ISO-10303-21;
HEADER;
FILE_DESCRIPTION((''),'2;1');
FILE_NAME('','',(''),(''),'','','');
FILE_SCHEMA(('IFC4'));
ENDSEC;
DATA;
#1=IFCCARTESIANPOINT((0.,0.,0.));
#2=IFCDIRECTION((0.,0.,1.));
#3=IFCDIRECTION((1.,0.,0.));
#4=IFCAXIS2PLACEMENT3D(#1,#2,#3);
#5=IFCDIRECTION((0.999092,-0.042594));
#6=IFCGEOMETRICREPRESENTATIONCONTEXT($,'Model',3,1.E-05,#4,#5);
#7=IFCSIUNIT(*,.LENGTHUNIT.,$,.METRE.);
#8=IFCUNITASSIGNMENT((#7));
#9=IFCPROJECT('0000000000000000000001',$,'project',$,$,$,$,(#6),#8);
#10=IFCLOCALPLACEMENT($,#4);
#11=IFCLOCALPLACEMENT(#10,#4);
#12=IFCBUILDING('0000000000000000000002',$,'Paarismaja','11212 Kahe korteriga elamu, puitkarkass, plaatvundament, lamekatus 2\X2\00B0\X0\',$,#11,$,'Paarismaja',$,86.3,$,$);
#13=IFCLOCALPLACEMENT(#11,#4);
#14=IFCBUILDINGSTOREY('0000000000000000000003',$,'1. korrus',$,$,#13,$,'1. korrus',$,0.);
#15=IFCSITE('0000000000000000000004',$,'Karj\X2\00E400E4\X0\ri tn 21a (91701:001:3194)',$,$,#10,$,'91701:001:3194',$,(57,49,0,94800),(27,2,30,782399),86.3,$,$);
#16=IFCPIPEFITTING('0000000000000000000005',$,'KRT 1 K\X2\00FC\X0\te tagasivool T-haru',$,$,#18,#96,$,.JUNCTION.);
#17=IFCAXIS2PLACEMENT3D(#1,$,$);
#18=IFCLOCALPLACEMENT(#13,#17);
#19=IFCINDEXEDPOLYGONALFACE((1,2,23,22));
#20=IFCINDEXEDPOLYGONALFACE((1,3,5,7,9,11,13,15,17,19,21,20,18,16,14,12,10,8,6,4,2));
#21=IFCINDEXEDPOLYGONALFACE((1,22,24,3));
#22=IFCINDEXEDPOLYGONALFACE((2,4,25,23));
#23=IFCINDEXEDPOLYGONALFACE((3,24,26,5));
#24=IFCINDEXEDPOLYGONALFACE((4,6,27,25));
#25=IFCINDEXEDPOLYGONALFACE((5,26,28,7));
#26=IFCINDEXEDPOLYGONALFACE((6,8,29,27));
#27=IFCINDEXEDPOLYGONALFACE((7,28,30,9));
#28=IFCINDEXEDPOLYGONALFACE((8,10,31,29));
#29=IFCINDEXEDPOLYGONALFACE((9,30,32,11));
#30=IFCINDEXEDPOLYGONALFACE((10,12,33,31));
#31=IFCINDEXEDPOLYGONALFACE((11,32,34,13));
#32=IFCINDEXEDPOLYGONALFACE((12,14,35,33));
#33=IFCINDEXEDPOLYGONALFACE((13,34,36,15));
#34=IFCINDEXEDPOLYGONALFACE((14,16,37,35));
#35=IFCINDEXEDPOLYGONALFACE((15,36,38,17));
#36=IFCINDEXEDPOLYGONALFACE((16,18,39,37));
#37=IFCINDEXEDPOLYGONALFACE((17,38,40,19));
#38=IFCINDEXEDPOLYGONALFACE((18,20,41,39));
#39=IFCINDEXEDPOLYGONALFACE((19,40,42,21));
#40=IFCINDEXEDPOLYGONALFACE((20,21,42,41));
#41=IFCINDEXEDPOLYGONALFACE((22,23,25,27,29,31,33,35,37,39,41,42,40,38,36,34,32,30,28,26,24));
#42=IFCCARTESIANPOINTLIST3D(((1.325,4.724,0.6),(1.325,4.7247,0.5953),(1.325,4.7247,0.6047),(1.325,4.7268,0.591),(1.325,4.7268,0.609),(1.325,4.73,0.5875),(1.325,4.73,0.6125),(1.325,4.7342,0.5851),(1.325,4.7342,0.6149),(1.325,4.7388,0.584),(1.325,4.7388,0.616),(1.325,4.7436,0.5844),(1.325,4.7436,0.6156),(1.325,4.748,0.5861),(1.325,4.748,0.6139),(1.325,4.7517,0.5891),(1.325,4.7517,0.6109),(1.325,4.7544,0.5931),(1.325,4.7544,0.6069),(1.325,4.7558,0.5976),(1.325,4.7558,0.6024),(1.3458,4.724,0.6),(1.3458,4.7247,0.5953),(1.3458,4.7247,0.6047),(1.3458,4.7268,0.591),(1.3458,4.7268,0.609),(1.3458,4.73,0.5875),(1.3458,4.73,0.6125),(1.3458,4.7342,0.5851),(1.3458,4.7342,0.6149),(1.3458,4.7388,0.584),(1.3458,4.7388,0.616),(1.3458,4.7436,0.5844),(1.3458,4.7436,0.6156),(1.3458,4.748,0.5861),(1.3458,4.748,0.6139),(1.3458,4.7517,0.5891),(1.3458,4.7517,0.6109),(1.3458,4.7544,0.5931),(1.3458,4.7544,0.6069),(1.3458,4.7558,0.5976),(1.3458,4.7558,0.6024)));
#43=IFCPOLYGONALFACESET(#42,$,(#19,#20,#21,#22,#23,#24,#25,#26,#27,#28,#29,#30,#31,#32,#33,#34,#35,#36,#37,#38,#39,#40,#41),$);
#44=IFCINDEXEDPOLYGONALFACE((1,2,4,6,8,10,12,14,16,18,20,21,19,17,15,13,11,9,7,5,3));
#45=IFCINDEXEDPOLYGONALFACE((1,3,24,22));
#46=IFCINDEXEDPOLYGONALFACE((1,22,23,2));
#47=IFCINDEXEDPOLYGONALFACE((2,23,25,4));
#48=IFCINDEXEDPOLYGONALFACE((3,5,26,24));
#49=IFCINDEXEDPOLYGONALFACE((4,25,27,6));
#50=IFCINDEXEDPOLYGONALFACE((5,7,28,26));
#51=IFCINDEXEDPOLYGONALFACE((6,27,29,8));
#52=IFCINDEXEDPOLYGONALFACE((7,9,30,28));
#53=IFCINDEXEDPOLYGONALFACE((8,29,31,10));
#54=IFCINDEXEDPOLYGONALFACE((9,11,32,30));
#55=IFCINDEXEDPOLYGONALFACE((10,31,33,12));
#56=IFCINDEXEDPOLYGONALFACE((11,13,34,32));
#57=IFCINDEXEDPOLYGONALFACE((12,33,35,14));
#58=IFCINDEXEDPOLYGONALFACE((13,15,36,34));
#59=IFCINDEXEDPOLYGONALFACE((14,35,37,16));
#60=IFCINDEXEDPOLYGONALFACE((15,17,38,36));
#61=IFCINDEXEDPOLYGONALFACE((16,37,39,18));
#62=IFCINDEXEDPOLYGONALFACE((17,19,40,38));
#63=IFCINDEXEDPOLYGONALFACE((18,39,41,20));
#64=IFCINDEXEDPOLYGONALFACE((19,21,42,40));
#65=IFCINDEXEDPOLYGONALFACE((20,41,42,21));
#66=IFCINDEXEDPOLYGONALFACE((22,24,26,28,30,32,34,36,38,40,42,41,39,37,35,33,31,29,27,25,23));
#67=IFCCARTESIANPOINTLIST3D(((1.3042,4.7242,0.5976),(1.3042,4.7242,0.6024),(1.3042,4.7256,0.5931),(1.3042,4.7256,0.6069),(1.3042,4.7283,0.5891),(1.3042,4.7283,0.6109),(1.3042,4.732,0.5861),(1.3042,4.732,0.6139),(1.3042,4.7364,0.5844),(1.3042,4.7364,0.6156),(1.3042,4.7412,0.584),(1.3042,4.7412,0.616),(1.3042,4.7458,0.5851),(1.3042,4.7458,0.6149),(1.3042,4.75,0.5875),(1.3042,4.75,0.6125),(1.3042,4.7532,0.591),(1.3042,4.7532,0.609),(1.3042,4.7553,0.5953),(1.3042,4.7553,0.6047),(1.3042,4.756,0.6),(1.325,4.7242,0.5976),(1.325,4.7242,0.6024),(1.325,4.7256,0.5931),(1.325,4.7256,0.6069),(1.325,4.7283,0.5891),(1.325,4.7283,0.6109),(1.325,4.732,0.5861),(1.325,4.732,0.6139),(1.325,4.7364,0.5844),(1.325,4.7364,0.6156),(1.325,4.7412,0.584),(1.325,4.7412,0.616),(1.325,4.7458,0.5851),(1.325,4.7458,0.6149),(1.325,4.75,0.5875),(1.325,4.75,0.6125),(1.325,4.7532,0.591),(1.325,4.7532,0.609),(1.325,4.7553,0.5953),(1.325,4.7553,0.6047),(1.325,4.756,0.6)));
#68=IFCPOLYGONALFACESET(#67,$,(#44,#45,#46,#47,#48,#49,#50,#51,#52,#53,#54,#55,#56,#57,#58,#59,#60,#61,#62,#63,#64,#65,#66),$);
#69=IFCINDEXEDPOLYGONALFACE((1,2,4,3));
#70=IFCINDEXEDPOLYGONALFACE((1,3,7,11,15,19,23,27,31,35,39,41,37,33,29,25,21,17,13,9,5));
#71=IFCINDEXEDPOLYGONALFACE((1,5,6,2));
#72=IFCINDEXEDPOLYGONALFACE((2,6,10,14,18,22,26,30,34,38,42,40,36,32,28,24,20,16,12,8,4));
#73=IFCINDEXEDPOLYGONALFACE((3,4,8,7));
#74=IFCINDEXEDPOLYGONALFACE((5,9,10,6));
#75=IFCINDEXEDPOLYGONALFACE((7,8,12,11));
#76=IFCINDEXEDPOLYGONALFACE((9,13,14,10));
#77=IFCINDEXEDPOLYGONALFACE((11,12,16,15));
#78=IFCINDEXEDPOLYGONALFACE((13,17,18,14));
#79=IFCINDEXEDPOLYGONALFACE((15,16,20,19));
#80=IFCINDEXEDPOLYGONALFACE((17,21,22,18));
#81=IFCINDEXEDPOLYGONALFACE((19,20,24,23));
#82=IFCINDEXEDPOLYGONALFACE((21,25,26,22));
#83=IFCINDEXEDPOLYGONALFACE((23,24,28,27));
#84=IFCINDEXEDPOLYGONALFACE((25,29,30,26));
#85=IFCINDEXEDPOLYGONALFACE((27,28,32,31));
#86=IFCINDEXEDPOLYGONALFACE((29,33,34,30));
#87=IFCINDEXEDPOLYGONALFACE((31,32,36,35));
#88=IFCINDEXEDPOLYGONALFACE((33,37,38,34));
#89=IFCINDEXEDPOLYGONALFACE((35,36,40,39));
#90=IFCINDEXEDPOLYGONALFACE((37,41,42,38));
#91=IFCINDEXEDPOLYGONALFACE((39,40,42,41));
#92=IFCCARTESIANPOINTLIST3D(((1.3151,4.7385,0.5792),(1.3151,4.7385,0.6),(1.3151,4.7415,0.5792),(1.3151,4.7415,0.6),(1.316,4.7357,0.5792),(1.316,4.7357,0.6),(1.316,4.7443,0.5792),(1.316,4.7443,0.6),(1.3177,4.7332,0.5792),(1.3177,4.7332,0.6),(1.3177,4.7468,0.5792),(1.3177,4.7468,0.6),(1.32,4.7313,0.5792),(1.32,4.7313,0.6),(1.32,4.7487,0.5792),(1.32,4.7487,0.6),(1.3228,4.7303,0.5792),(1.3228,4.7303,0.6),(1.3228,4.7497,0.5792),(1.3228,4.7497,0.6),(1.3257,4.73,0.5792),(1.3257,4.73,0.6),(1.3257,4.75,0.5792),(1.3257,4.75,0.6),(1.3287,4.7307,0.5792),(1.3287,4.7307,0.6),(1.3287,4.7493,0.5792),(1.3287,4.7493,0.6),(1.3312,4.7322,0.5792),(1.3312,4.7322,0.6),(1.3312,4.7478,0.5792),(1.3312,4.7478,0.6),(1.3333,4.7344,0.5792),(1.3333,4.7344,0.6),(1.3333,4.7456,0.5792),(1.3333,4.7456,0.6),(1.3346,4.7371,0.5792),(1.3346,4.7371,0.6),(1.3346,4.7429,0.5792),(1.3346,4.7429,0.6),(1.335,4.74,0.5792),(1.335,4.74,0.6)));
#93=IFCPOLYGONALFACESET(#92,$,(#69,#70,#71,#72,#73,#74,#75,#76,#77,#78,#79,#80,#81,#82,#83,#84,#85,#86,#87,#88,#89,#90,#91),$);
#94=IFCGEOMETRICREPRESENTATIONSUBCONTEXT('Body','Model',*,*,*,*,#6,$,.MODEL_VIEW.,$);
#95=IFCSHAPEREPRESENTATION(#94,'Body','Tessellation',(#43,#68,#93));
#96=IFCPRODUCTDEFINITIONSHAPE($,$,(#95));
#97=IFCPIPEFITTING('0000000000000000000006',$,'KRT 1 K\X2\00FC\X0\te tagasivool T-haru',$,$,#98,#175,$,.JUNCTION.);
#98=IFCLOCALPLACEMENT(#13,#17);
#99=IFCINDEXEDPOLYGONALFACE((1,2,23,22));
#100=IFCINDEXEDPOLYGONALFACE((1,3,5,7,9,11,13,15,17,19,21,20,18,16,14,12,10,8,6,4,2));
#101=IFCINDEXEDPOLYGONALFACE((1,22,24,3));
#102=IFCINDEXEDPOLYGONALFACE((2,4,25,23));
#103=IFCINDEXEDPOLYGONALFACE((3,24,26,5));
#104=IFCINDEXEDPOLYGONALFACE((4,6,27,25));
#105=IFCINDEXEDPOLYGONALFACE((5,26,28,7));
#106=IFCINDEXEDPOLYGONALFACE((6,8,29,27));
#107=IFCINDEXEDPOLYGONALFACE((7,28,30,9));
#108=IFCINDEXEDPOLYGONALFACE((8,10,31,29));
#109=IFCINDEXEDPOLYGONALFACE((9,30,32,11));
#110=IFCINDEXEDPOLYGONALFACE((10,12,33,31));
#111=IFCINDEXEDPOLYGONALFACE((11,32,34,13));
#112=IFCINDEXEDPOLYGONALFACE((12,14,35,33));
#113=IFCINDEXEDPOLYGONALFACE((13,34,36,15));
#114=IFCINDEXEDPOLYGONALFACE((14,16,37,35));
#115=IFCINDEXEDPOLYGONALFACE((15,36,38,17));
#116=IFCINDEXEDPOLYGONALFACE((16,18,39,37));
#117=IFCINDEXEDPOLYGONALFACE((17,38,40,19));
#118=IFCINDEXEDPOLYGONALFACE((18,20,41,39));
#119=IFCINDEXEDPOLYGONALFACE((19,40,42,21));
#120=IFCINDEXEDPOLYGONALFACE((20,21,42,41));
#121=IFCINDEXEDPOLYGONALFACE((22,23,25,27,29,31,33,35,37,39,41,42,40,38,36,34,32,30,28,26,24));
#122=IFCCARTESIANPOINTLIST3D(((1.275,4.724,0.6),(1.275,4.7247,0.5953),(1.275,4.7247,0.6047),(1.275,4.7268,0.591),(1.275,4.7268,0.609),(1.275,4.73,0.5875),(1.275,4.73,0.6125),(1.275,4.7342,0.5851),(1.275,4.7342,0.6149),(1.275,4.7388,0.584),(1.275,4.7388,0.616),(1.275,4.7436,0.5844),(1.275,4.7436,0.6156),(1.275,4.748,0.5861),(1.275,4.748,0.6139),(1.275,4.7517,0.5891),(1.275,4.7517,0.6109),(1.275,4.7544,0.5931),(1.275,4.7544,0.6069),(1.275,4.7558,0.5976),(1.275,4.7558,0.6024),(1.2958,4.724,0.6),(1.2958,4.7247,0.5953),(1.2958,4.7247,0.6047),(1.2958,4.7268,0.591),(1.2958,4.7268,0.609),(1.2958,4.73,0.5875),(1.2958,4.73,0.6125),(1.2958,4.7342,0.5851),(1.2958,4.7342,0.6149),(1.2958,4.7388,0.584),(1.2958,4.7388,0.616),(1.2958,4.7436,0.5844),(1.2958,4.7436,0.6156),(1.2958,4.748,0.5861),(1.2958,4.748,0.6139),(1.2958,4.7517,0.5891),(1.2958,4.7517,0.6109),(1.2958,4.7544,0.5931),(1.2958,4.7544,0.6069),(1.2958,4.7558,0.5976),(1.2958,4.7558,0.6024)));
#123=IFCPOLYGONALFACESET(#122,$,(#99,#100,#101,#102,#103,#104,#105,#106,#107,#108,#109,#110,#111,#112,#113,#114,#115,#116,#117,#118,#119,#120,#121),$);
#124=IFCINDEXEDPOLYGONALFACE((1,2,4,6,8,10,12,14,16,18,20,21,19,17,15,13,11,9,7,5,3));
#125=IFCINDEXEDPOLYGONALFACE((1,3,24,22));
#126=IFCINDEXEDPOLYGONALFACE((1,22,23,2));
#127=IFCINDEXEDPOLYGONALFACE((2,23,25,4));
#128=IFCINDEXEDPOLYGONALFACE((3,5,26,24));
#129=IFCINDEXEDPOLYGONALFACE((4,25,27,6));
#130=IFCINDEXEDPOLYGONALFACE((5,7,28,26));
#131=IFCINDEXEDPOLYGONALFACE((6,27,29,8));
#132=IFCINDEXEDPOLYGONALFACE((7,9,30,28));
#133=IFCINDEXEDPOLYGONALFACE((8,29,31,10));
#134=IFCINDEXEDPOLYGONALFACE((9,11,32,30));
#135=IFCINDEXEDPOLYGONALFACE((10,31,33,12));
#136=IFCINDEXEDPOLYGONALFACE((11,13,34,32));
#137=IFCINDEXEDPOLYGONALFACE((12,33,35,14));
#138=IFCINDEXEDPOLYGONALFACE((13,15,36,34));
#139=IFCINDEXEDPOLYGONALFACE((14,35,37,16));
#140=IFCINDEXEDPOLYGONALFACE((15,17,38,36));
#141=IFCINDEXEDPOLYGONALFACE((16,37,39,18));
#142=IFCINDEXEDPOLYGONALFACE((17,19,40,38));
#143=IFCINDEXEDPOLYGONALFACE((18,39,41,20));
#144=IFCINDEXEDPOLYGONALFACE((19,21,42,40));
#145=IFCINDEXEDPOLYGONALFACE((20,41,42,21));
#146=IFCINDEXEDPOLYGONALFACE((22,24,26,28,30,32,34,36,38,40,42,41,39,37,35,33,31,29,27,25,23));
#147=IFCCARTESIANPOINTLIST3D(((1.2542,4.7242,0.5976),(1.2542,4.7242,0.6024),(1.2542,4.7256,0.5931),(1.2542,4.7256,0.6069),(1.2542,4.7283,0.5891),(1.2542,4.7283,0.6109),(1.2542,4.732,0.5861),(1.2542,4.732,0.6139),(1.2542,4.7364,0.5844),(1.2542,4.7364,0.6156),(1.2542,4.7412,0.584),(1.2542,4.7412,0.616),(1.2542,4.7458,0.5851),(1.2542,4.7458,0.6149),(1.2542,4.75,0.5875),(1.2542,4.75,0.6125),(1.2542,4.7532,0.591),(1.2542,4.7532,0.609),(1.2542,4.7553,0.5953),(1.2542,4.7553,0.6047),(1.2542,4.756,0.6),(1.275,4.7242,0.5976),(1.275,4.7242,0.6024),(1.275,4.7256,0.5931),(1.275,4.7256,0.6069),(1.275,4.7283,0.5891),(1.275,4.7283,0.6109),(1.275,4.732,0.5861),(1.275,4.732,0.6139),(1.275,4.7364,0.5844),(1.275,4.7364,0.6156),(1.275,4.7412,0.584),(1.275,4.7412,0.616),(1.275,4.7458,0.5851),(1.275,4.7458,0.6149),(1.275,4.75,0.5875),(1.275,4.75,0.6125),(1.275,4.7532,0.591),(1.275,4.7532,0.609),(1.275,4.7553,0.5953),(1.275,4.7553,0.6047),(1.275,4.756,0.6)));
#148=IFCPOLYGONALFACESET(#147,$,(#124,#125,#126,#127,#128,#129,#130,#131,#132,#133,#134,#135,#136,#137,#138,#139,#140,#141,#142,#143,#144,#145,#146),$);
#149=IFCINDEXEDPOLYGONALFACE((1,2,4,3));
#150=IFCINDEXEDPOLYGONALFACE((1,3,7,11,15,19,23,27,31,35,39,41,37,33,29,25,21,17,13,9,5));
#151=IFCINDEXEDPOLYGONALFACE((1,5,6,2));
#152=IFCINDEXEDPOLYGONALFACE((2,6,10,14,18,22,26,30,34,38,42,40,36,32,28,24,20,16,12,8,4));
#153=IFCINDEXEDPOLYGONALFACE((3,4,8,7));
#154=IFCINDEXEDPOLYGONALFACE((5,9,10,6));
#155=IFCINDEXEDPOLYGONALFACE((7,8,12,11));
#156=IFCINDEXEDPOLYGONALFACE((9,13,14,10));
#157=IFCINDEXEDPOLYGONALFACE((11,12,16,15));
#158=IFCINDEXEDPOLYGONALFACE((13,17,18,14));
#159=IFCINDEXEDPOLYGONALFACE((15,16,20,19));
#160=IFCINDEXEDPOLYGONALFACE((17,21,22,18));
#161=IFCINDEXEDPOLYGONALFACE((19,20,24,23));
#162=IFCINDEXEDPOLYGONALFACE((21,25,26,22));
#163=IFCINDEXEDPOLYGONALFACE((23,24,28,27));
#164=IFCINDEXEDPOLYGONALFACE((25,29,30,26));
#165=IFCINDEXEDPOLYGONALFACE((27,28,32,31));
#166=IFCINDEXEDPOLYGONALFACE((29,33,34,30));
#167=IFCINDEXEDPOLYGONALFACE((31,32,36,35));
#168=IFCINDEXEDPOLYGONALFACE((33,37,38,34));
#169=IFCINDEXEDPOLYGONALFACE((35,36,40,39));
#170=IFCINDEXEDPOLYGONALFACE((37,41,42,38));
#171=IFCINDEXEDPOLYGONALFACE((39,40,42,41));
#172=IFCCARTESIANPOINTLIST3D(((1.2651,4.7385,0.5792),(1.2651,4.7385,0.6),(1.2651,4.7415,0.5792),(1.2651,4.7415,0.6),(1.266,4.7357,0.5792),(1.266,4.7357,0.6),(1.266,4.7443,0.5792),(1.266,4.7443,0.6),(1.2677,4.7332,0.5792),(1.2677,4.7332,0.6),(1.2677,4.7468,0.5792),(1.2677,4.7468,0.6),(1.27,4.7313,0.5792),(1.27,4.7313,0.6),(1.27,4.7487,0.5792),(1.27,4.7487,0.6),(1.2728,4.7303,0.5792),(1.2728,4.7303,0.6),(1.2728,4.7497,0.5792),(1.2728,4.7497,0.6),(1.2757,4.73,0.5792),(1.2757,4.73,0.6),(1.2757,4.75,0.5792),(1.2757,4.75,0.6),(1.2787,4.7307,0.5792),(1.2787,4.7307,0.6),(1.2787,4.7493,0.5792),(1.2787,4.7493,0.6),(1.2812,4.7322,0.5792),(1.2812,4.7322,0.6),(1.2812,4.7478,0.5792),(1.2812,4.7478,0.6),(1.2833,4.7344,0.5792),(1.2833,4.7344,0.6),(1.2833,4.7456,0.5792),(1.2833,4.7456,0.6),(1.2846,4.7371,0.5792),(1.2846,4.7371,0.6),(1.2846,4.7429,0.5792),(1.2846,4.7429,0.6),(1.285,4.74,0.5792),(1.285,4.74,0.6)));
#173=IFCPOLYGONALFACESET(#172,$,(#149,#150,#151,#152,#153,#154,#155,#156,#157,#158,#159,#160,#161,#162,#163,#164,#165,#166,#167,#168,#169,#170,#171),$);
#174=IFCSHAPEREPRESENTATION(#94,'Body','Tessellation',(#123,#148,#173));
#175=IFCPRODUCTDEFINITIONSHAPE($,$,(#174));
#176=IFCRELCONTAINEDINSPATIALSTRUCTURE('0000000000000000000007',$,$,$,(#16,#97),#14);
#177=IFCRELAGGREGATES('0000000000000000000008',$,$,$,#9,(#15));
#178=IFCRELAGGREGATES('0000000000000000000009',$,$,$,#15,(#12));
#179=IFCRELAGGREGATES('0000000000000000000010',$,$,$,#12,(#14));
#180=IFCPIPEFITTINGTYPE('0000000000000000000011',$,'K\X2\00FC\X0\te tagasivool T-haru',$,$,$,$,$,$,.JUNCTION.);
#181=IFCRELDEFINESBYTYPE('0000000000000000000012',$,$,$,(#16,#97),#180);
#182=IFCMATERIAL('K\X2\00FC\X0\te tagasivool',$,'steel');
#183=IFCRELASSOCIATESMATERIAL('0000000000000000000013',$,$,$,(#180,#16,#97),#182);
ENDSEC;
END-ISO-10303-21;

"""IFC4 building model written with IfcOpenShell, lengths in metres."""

from ifc_helpers import new_model, si_unit, direction, frame, origin_with_axes, place, context, subcontext, project, spatial, circle, extrude, material, type_object, element, save


model = new_model("IFC4")

# Units and contexts
model_context = context("Model", 3, precision=1e-05, world=origin_with_axes(), true_north=direction((0.999092, -0.042594)))
body_context = subcontext(model_context, "Body", "Model", "MODEL_VIEW")
ifc_project = project(units=[si_unit("LENGTHUNIT", "METRE")], contexts=[model_context])

# Site, building, storey
site_placement = place(None, origin_with_axes())
site = spatial("IfcSite", under=ifc_project, at=site_placement, Name="Karjääri tn 21a (91701:001:3194)", LongName="91701:001:3194", RefLatitude=(57, 49, 0, 94800), RefLongitude=(27, 2, 30, 782399), RefElevation=86.3)
building_placement = place(site_placement, origin_with_axes())
building = spatial("IfcBuilding", under=site, at=building_placement, Name="Paarismaja", Description="11212 Kahe korteriga elamu, puitkarkass, plaatvundament, lamekatus 2°", LongName="Paarismaja", ElevationOfRefHeight=86.3)
storey_placement = place(building_placement, origin_with_axes())
storey = spatial("IfcBuildingStorey", under=building, at=storey_placement, Name="1. korrus", LongName="1. korrus", Elevation=0.0)

# Pipe fittings
ifc_material_1 = material(Name="Küte tagasivool", Category="steel")
pipe_fitting_type_1 = type_object("IfcPipeFittingType", Name="Küte tagasivool T-haru", PredefinedType="JUNCTION", material=ifc_material_1)
for number, where, z_axis, x_axis, name in (
    (1, (1.325, 4.74, 0.6), (0.0, 0.0, 1.0), (1.0, 0.0, 0.0), "KRT 1 Küte tagasivool T-haru"),
    (2, (1.275, 4.74, 0.6), (0.0, 0.0, 1.0), (1.0, 0.0, 0.0), "KRT 1 Küte tagasivool T-haru"),
):
    element("IfcPipeFitting", number, at=place(storey_placement, frame(where, z_axis=z_axis, x_axis=x_axis)), inside=storey, type_object=pipe_fitting_type_1, material=ifc_material_1, Name=name, PredefinedType="JUNCTION", context=body_context, shape_type="SweptSolid", body=[
        extrude(circle(Radius=0.016), frame((0.0, 0.0, 0.0), z_axis=(1.0, 0.0, 0.0), x_axis=(0.0, -1.0, 0.0)), (0.0, 0.0, 1.0), 0.0208),
        extrude(circle(Radius=0.016), frame((0.0, 0.0, 0.0), z_axis=(-1.0, 0.0, 0.0), x_axis=(0.0, 1.0, 0.0)), (0.0, 0.0, 1.0), 0.0208),
        extrude(circle(Radius=0.01), frame((0.0, 0.0, 0.0), z_axis=(0.0, 0.0, -1.0), x_axis=(1.0, 0.0, 0.0)), (0.0, 0.0, 1.0), 0.0208),
    ])

save(model, "model.ifc")
